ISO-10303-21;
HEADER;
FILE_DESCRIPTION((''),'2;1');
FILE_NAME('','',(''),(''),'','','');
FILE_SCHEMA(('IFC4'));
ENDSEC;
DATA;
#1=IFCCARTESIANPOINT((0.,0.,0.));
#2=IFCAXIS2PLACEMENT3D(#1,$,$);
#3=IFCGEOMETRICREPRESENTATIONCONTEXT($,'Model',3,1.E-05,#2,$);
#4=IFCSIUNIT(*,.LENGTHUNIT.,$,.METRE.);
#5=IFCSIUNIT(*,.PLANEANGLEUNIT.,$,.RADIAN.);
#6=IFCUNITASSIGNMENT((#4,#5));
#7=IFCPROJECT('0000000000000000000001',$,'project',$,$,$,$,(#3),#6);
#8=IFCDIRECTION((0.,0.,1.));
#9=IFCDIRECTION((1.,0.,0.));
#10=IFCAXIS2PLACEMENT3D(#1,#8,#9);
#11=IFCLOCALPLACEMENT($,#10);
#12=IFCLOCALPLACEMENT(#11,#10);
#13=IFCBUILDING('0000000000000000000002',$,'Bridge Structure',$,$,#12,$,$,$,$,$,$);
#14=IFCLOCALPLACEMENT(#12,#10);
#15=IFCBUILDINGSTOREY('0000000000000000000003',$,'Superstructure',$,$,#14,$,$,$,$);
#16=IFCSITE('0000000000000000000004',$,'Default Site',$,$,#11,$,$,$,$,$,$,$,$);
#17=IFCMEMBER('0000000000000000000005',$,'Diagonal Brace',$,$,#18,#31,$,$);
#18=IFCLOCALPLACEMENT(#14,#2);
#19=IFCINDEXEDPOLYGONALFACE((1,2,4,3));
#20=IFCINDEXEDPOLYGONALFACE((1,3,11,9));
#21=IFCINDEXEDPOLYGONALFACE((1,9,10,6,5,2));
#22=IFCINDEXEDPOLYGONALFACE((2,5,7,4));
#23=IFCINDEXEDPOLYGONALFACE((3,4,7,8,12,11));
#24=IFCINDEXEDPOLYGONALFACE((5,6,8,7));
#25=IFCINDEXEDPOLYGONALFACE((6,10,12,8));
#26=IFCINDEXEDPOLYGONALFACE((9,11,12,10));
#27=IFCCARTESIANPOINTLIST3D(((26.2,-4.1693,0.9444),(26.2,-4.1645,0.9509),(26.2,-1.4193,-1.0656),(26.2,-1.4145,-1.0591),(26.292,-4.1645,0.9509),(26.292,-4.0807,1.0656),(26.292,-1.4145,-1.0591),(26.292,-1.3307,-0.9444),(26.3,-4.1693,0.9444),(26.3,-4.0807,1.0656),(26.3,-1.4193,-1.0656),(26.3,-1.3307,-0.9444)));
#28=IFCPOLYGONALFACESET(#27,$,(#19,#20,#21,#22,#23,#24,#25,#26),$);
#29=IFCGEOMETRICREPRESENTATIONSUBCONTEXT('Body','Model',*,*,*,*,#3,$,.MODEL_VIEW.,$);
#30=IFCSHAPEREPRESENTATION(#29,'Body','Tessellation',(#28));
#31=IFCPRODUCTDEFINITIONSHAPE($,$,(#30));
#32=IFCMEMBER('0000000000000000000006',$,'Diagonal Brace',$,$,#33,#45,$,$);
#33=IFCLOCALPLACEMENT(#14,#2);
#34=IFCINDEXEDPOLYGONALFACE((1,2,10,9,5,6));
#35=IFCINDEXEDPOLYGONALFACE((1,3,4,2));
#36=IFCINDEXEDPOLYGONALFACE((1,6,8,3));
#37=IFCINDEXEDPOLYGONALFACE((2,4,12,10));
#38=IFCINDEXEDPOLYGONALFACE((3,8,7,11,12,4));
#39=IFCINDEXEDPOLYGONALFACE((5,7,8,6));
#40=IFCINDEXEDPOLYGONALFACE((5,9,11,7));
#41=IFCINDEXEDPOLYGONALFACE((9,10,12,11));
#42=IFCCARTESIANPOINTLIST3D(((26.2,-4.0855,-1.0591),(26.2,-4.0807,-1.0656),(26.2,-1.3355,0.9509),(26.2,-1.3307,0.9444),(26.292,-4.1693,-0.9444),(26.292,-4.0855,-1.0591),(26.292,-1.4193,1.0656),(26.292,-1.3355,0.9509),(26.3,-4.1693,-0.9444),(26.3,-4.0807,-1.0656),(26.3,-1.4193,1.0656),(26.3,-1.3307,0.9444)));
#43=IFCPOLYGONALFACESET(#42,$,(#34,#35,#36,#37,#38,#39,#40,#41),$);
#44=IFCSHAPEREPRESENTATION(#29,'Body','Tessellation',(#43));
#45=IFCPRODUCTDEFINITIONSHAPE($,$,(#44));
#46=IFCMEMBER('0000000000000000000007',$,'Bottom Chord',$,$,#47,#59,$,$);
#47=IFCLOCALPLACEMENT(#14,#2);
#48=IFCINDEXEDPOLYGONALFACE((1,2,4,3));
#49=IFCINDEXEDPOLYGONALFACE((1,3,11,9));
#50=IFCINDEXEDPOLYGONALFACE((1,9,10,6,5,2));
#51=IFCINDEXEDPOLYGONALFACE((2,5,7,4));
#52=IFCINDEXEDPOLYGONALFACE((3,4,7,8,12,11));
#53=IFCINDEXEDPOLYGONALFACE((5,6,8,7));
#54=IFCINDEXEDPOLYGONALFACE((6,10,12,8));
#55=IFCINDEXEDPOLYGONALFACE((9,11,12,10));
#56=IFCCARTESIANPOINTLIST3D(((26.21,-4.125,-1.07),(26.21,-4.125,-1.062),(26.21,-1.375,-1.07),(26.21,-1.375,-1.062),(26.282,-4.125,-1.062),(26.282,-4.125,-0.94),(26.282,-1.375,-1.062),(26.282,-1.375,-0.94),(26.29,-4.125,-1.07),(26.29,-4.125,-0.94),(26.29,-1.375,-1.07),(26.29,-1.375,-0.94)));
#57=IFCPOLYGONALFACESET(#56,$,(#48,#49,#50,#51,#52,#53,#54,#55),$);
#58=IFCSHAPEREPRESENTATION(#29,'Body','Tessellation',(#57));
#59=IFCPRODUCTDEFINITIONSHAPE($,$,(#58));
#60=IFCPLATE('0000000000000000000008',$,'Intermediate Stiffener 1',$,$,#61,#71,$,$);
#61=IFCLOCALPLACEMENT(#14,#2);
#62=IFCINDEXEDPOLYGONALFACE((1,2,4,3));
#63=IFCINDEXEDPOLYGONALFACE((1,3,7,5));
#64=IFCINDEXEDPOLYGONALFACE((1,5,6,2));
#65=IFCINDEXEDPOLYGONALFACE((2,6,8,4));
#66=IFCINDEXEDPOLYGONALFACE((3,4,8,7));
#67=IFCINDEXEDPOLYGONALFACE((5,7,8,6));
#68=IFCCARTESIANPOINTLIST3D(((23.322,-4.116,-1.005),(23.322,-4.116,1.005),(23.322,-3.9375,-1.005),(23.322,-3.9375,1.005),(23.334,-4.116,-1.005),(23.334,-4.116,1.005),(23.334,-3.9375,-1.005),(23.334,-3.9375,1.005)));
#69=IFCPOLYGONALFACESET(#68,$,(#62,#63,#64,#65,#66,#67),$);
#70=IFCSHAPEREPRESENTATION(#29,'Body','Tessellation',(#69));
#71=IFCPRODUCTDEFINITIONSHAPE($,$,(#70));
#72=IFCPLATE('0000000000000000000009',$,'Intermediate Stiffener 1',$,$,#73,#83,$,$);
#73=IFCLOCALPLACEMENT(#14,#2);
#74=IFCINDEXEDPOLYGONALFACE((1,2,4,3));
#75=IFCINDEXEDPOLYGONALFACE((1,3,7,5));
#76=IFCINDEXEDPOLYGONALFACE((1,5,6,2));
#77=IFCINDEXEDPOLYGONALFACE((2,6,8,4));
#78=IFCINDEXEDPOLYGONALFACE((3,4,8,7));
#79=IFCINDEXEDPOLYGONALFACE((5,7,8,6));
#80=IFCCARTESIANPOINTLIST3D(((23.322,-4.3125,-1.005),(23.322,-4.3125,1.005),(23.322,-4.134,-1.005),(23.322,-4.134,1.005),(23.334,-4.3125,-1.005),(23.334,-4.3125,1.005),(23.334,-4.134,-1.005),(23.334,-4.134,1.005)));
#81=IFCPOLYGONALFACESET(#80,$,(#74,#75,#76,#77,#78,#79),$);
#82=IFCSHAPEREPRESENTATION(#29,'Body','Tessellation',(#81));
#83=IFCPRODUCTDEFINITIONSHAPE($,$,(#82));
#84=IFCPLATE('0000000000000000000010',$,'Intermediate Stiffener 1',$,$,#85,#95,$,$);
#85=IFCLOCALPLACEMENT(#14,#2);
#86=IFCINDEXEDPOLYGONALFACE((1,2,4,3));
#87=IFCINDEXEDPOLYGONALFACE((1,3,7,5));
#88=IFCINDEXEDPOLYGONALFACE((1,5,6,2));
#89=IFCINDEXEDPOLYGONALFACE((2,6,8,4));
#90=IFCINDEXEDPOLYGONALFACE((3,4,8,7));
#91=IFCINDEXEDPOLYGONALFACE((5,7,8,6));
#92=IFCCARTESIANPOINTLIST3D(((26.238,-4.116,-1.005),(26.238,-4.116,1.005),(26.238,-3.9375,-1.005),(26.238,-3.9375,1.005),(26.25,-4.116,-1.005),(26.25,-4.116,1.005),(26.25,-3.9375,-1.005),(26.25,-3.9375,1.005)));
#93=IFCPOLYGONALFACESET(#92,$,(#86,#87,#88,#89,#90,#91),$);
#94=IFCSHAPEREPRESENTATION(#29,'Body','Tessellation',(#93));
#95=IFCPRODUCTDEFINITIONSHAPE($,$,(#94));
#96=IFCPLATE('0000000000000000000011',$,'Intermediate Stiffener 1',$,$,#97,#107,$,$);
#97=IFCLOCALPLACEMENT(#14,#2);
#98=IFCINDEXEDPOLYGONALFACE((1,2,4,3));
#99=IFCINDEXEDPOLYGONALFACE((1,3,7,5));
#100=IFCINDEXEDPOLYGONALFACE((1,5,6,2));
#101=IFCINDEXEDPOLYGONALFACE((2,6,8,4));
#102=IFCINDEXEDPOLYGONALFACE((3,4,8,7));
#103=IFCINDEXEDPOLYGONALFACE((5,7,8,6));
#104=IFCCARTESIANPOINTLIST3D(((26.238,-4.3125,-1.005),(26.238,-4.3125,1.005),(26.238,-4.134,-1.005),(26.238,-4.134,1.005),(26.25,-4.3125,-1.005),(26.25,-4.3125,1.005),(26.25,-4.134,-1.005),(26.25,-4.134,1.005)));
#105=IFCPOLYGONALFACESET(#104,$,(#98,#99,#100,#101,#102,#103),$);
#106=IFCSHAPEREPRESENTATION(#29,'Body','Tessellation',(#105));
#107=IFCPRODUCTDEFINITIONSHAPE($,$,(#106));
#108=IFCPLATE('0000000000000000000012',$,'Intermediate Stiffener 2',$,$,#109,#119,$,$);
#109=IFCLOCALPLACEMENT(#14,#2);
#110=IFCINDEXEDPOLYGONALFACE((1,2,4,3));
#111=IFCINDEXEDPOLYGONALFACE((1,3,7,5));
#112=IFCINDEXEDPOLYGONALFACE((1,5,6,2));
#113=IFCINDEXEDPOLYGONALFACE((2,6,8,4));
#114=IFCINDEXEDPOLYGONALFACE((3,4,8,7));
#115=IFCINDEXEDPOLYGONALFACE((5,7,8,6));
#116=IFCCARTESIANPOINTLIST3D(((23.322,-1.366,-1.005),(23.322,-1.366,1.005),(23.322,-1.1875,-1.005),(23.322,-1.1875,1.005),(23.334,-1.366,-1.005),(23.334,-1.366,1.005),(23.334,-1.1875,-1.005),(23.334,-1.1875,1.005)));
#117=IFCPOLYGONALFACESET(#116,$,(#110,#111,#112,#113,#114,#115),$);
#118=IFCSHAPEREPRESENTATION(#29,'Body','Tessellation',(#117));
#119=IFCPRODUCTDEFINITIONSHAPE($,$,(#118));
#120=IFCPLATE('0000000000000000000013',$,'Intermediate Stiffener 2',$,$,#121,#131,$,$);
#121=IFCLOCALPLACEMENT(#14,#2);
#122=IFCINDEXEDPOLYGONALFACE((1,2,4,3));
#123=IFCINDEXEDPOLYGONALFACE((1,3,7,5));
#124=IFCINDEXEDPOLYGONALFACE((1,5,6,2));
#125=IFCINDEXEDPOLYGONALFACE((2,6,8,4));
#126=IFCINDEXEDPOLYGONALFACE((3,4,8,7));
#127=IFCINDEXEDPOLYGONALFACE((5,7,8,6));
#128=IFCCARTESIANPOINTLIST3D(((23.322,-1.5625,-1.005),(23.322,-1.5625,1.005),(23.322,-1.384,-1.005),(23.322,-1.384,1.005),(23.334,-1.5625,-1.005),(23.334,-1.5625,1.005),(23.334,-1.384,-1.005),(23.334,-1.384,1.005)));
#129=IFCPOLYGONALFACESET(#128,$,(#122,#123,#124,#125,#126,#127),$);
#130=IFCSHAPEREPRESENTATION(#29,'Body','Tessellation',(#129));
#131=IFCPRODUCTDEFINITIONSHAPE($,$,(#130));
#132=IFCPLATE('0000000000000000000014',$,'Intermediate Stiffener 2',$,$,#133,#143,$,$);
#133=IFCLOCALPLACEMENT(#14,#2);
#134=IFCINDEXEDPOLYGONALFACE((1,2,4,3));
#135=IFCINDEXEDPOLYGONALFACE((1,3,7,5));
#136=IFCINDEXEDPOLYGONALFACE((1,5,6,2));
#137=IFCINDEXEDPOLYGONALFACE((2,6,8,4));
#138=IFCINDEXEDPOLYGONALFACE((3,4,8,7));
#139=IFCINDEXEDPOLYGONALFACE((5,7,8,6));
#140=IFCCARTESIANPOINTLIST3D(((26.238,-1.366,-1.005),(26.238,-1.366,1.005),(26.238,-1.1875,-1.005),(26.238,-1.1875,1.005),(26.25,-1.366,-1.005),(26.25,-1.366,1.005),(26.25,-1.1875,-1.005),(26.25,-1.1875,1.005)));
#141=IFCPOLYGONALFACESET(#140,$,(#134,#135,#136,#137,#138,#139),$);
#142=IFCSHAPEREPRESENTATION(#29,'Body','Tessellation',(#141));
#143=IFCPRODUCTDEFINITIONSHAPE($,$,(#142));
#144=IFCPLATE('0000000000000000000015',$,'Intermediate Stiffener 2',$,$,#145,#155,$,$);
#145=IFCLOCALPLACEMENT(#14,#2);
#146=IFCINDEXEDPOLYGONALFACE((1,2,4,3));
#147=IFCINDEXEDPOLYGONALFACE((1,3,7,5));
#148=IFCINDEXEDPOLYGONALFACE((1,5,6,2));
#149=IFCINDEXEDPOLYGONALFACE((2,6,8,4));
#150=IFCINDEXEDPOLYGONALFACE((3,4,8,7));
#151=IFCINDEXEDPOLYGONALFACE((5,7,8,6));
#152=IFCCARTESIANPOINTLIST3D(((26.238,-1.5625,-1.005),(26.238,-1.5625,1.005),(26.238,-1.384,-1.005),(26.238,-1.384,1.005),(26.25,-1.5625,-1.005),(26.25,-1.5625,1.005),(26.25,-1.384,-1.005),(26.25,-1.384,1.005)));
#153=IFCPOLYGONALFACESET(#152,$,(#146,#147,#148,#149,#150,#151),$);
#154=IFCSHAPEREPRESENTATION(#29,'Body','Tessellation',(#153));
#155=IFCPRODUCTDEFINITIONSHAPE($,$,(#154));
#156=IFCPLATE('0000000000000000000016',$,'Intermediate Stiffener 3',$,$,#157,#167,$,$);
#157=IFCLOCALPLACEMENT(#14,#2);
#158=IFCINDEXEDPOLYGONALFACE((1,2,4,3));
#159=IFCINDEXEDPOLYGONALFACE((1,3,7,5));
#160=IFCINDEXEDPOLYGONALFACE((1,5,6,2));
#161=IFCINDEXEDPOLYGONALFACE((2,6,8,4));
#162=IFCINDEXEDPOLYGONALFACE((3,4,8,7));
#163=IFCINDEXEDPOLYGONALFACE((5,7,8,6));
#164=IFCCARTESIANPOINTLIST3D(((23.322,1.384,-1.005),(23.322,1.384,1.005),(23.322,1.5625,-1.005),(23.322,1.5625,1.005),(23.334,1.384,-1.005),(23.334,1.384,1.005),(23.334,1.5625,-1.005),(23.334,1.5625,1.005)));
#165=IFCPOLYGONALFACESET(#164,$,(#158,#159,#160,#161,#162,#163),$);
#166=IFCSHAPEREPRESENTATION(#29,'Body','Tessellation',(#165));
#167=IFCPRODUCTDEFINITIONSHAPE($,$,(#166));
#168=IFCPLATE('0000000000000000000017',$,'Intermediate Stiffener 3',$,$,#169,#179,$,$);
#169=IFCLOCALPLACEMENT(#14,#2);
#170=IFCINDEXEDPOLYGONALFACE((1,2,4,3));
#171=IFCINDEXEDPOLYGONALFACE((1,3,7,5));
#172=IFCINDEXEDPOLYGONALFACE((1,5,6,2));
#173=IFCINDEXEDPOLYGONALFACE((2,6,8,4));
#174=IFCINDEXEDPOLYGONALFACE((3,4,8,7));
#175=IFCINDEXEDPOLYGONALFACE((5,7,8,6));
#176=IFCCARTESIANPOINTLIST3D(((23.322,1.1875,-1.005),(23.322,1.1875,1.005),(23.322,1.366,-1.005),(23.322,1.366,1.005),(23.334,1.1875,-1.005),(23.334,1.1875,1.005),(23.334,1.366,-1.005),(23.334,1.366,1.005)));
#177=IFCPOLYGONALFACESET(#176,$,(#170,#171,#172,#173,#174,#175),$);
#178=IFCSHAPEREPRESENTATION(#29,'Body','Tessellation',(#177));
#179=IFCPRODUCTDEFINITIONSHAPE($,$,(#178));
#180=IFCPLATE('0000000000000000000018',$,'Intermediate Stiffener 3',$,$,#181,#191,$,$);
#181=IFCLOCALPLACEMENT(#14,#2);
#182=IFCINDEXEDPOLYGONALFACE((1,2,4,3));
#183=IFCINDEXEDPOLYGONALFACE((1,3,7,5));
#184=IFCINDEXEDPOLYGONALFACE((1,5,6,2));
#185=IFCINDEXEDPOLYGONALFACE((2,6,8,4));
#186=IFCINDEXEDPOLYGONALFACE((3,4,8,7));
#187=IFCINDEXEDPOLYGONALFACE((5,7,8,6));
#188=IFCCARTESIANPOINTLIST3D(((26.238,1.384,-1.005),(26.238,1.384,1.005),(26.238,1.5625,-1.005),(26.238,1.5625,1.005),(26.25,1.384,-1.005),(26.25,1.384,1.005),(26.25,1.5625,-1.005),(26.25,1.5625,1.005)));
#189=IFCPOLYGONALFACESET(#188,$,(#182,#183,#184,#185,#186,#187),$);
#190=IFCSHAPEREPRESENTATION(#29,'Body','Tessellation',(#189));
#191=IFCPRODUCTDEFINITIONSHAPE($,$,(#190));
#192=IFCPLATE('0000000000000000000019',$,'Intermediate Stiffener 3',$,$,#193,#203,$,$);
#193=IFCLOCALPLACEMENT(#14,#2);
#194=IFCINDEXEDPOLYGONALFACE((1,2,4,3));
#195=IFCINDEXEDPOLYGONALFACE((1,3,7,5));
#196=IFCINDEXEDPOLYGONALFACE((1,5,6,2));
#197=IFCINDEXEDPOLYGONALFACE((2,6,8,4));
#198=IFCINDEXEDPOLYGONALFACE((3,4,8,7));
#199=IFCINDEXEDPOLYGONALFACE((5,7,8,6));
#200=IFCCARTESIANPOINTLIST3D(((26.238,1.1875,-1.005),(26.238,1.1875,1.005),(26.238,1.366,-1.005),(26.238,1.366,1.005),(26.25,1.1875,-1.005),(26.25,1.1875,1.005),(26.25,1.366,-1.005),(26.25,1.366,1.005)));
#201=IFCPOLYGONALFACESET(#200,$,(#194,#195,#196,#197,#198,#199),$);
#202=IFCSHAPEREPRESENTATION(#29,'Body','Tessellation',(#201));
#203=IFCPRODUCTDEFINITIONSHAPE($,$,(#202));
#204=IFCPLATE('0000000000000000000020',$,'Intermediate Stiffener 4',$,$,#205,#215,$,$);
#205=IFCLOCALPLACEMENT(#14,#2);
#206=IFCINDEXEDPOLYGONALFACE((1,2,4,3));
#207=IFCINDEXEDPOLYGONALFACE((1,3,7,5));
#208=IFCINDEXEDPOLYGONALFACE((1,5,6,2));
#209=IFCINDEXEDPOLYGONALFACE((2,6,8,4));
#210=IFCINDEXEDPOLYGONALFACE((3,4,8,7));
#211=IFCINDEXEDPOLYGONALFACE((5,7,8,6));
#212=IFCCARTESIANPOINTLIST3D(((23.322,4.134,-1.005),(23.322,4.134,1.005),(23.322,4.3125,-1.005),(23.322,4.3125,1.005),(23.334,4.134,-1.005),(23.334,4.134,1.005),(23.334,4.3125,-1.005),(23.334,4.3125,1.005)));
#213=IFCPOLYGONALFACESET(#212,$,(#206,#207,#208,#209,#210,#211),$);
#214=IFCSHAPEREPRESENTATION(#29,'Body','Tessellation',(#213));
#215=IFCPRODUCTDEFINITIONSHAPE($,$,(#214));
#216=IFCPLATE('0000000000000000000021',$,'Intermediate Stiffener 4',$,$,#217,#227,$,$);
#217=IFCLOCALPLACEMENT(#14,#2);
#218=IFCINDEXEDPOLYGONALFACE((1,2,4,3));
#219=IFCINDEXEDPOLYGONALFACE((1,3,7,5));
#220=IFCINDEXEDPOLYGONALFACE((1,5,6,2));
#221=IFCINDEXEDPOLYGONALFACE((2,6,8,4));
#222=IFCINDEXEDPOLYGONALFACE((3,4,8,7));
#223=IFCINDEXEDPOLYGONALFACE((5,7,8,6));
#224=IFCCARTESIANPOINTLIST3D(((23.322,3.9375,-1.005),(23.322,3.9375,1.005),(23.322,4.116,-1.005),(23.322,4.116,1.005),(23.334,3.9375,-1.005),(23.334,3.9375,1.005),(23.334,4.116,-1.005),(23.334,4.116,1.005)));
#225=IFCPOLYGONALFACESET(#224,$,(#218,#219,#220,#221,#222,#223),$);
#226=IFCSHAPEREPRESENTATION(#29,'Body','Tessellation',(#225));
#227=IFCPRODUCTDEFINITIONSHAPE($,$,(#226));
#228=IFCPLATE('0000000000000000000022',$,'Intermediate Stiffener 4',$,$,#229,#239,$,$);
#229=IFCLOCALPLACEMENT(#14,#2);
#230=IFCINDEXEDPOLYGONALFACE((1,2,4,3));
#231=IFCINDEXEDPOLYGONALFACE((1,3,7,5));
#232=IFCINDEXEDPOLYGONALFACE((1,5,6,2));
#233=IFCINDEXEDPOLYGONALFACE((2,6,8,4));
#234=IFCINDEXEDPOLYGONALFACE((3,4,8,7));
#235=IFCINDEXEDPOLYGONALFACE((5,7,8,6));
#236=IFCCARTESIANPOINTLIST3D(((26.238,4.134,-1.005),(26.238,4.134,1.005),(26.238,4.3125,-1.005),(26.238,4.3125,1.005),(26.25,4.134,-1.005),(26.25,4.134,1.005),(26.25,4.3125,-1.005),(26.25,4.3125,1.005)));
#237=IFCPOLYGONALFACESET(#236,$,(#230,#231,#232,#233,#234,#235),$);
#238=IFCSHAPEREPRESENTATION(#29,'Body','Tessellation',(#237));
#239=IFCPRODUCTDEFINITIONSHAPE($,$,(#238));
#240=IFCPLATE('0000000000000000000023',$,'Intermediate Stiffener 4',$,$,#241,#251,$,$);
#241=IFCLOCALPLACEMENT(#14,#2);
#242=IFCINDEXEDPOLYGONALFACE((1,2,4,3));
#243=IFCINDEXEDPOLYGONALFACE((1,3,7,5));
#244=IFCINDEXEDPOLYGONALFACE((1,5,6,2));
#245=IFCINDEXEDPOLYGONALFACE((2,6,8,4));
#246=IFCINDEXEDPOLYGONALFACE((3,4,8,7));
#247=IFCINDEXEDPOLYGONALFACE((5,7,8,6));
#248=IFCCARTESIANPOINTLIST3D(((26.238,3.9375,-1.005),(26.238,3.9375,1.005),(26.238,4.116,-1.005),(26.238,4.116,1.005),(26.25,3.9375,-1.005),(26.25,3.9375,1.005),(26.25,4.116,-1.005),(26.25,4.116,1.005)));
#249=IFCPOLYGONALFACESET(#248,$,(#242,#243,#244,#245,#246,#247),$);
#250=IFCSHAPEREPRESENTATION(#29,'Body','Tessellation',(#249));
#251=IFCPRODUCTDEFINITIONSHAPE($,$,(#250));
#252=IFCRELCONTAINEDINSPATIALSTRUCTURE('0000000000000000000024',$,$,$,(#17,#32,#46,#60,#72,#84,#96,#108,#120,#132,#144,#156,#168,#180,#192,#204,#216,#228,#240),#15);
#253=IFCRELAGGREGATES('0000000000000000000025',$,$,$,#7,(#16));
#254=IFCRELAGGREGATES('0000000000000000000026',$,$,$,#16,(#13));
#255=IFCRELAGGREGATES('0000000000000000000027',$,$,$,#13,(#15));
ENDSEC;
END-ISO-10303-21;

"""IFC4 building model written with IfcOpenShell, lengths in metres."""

from ifc_helpers import new_model, si_unit, frame, origin, origin_with_axes, origin_2d_with_axis, place, context, subcontext, project, spatial, rectangle, l_section, extrude, element, save


model = new_model("IFC4")

# Units and contexts
model_context = context("Model", 3, precision=1e-05, world=origin())
body_context = subcontext(model_context, "Body", "Model", "MODEL_VIEW")
ifc_project = project(units=[si_unit("LENGTHUNIT", "METRE"), si_unit("PLANEANGLEUNIT", "RADIAN")], contexts=[model_context])

# Site, building, storey
site_placement = place(None, origin_with_axes())
site = spatial("IfcSite", under=ifc_project, at=site_placement, Name="Default Site")
building_placement = place(site_placement, origin_with_axes())
building = spatial("IfcBuilding", under=site, at=building_placement, Name="Bridge Structure")
storey_placement = place(building_placement, origin_with_axes())
storey = spatial("IfcBuildingStorey", under=building, at=storey_placement, Name="Superstructure")

# Members
for number, where, z_axis, x_axis, name in (
    (1, (26.25, -4.125, 1.005), (0.0, 0.807337, -0.59009), (-1.0, 0.0, 0.0), "Diagonal Brace"),
    (2, (26.25, -4.125, -1.005), (0.0, 0.807337, 0.59009), (-1.0, 0.0, 0.0), "Diagonal Brace"),
):
    element("IfcMember", number, at=place(storey_placement, frame(where, z_axis=z_axis, x_axis=x_axis)), inside=storey, Name=name, context=body_context, shape_type="SweptSolid", body=[
        extrude(l_section(Depth=0.15, Width=0.1, Thickness=0.008, at=origin_2d_with_axis()), origin_with_axes(), (0.0, 0.0, 1.0), 3.4063),
    ])
member_1_placement = place(storey_placement, frame((26.25, -4.125, -1.005), z_axis=(0.0, 1.0, 0.0), x_axis=(-1.0, 0.0, 0.0)))
element("IfcMember", 3, at=member_1_placement, inside=storey, Name="Bottom Chord", context=body_context, shape_type="SweptSolid", body=[
    extrude(l_section(Depth=0.13, Width=0.08, Thickness=0.008, at=origin_2d_with_axis()), origin_with_axes(), (0.0, 0.0, 1.0), 2.75),
])

# Plates
for number, where, z_axis, x_axis, name in (
    (4, (23.328, -4.0267, -1.005), (0.0, 0.0, 1.0), (1.0, 0.0, 0.0), "Intermediate Stiffener 1"),
    (5, (23.328, -4.2233, -1.005), (0.0, 0.0, 1.0), (1.0, 0.0, 0.0), "Intermediate Stiffener 1"),
    (6, (26.244, -4.0267, -1.005), (0.0, 0.0, 1.0), (1.0, 0.0, 0.0), "Intermediate Stiffener 1"),
    (7, (26.244, -4.2233, -1.005), (0.0, 0.0, 1.0), (1.0, 0.0, 0.0), "Intermediate Stiffener 1"),
    (8, (23.328, -1.2768, -1.005), (0.0, 0.0, 1.0), (1.0, 0.0, 0.0), "Intermediate Stiffener 2"),
    (9, (23.328, -1.4732, -1.005), (0.0, 0.0, 1.0), (1.0, 0.0, 0.0), "Intermediate Stiffener 2"),
    (10, (26.244, -1.2768, -1.005), (0.0, 0.0, 1.0), (1.0, 0.0, 0.0), "Intermediate Stiffener 2"),
    (11, (26.244, -1.4732, -1.005), (0.0, 0.0, 1.0), (1.0, 0.0, 0.0), "Intermediate Stiffener 2"),
    (12, (23.328, 1.4732, -1.005), (0.0, 0.0, 1.0), (1.0, 0.0, 0.0), "Intermediate Stiffener 3"),
    (13, (23.328, 1.2768, -1.005), (0.0, 0.0, 1.0), (1.0, 0.0, 0.0), "Intermediate Stiffener 3"),
    (14, (26.244, 1.4732, -1.005), (0.0, 0.0, 1.0), (1.0, 0.0, 0.0), "Intermediate Stiffener 3"),
    (15, (26.244, 1.2768, -1.005), (0.0, 0.0, 1.0), (1.0, 0.0, 0.0), "Intermediate Stiffener 3"),
    (16, (23.328, 4.2233, -1.005), (0.0, 0.0, 1.0), (1.0, 0.0, 0.0), "Intermediate Stiffener 4"),
    (17, (23.328, 4.0267, -1.005), (0.0, 0.0, 1.0), (1.0, 0.0, 0.0), "Intermediate Stiffener 4"),
    (18, (26.244, 4.2233, -1.005), (0.0, 0.0, 1.0), (1.0, 0.0, 0.0), "Intermediate Stiffener 4"),
    (19, (26.244, 4.0267, -1.005), (0.0, 0.0, 1.0), (1.0, 0.0, 0.0), "Intermediate Stiffener 4"),
):
    element("IfcPlate", number, at=place(storey_placement, frame(where, z_axis=z_axis, x_axis=x_axis)), inside=storey, Name=name, context=body_context, shape_type="SweptSolid", body=[
        extrude(rectangle(XDim=0.012, YDim=0.1785, at=origin_2d_with_axis()), origin_with_axes(), (0.0, 0.0, 1.0), 2.01),
    ])

save(model, "model.ifc")
